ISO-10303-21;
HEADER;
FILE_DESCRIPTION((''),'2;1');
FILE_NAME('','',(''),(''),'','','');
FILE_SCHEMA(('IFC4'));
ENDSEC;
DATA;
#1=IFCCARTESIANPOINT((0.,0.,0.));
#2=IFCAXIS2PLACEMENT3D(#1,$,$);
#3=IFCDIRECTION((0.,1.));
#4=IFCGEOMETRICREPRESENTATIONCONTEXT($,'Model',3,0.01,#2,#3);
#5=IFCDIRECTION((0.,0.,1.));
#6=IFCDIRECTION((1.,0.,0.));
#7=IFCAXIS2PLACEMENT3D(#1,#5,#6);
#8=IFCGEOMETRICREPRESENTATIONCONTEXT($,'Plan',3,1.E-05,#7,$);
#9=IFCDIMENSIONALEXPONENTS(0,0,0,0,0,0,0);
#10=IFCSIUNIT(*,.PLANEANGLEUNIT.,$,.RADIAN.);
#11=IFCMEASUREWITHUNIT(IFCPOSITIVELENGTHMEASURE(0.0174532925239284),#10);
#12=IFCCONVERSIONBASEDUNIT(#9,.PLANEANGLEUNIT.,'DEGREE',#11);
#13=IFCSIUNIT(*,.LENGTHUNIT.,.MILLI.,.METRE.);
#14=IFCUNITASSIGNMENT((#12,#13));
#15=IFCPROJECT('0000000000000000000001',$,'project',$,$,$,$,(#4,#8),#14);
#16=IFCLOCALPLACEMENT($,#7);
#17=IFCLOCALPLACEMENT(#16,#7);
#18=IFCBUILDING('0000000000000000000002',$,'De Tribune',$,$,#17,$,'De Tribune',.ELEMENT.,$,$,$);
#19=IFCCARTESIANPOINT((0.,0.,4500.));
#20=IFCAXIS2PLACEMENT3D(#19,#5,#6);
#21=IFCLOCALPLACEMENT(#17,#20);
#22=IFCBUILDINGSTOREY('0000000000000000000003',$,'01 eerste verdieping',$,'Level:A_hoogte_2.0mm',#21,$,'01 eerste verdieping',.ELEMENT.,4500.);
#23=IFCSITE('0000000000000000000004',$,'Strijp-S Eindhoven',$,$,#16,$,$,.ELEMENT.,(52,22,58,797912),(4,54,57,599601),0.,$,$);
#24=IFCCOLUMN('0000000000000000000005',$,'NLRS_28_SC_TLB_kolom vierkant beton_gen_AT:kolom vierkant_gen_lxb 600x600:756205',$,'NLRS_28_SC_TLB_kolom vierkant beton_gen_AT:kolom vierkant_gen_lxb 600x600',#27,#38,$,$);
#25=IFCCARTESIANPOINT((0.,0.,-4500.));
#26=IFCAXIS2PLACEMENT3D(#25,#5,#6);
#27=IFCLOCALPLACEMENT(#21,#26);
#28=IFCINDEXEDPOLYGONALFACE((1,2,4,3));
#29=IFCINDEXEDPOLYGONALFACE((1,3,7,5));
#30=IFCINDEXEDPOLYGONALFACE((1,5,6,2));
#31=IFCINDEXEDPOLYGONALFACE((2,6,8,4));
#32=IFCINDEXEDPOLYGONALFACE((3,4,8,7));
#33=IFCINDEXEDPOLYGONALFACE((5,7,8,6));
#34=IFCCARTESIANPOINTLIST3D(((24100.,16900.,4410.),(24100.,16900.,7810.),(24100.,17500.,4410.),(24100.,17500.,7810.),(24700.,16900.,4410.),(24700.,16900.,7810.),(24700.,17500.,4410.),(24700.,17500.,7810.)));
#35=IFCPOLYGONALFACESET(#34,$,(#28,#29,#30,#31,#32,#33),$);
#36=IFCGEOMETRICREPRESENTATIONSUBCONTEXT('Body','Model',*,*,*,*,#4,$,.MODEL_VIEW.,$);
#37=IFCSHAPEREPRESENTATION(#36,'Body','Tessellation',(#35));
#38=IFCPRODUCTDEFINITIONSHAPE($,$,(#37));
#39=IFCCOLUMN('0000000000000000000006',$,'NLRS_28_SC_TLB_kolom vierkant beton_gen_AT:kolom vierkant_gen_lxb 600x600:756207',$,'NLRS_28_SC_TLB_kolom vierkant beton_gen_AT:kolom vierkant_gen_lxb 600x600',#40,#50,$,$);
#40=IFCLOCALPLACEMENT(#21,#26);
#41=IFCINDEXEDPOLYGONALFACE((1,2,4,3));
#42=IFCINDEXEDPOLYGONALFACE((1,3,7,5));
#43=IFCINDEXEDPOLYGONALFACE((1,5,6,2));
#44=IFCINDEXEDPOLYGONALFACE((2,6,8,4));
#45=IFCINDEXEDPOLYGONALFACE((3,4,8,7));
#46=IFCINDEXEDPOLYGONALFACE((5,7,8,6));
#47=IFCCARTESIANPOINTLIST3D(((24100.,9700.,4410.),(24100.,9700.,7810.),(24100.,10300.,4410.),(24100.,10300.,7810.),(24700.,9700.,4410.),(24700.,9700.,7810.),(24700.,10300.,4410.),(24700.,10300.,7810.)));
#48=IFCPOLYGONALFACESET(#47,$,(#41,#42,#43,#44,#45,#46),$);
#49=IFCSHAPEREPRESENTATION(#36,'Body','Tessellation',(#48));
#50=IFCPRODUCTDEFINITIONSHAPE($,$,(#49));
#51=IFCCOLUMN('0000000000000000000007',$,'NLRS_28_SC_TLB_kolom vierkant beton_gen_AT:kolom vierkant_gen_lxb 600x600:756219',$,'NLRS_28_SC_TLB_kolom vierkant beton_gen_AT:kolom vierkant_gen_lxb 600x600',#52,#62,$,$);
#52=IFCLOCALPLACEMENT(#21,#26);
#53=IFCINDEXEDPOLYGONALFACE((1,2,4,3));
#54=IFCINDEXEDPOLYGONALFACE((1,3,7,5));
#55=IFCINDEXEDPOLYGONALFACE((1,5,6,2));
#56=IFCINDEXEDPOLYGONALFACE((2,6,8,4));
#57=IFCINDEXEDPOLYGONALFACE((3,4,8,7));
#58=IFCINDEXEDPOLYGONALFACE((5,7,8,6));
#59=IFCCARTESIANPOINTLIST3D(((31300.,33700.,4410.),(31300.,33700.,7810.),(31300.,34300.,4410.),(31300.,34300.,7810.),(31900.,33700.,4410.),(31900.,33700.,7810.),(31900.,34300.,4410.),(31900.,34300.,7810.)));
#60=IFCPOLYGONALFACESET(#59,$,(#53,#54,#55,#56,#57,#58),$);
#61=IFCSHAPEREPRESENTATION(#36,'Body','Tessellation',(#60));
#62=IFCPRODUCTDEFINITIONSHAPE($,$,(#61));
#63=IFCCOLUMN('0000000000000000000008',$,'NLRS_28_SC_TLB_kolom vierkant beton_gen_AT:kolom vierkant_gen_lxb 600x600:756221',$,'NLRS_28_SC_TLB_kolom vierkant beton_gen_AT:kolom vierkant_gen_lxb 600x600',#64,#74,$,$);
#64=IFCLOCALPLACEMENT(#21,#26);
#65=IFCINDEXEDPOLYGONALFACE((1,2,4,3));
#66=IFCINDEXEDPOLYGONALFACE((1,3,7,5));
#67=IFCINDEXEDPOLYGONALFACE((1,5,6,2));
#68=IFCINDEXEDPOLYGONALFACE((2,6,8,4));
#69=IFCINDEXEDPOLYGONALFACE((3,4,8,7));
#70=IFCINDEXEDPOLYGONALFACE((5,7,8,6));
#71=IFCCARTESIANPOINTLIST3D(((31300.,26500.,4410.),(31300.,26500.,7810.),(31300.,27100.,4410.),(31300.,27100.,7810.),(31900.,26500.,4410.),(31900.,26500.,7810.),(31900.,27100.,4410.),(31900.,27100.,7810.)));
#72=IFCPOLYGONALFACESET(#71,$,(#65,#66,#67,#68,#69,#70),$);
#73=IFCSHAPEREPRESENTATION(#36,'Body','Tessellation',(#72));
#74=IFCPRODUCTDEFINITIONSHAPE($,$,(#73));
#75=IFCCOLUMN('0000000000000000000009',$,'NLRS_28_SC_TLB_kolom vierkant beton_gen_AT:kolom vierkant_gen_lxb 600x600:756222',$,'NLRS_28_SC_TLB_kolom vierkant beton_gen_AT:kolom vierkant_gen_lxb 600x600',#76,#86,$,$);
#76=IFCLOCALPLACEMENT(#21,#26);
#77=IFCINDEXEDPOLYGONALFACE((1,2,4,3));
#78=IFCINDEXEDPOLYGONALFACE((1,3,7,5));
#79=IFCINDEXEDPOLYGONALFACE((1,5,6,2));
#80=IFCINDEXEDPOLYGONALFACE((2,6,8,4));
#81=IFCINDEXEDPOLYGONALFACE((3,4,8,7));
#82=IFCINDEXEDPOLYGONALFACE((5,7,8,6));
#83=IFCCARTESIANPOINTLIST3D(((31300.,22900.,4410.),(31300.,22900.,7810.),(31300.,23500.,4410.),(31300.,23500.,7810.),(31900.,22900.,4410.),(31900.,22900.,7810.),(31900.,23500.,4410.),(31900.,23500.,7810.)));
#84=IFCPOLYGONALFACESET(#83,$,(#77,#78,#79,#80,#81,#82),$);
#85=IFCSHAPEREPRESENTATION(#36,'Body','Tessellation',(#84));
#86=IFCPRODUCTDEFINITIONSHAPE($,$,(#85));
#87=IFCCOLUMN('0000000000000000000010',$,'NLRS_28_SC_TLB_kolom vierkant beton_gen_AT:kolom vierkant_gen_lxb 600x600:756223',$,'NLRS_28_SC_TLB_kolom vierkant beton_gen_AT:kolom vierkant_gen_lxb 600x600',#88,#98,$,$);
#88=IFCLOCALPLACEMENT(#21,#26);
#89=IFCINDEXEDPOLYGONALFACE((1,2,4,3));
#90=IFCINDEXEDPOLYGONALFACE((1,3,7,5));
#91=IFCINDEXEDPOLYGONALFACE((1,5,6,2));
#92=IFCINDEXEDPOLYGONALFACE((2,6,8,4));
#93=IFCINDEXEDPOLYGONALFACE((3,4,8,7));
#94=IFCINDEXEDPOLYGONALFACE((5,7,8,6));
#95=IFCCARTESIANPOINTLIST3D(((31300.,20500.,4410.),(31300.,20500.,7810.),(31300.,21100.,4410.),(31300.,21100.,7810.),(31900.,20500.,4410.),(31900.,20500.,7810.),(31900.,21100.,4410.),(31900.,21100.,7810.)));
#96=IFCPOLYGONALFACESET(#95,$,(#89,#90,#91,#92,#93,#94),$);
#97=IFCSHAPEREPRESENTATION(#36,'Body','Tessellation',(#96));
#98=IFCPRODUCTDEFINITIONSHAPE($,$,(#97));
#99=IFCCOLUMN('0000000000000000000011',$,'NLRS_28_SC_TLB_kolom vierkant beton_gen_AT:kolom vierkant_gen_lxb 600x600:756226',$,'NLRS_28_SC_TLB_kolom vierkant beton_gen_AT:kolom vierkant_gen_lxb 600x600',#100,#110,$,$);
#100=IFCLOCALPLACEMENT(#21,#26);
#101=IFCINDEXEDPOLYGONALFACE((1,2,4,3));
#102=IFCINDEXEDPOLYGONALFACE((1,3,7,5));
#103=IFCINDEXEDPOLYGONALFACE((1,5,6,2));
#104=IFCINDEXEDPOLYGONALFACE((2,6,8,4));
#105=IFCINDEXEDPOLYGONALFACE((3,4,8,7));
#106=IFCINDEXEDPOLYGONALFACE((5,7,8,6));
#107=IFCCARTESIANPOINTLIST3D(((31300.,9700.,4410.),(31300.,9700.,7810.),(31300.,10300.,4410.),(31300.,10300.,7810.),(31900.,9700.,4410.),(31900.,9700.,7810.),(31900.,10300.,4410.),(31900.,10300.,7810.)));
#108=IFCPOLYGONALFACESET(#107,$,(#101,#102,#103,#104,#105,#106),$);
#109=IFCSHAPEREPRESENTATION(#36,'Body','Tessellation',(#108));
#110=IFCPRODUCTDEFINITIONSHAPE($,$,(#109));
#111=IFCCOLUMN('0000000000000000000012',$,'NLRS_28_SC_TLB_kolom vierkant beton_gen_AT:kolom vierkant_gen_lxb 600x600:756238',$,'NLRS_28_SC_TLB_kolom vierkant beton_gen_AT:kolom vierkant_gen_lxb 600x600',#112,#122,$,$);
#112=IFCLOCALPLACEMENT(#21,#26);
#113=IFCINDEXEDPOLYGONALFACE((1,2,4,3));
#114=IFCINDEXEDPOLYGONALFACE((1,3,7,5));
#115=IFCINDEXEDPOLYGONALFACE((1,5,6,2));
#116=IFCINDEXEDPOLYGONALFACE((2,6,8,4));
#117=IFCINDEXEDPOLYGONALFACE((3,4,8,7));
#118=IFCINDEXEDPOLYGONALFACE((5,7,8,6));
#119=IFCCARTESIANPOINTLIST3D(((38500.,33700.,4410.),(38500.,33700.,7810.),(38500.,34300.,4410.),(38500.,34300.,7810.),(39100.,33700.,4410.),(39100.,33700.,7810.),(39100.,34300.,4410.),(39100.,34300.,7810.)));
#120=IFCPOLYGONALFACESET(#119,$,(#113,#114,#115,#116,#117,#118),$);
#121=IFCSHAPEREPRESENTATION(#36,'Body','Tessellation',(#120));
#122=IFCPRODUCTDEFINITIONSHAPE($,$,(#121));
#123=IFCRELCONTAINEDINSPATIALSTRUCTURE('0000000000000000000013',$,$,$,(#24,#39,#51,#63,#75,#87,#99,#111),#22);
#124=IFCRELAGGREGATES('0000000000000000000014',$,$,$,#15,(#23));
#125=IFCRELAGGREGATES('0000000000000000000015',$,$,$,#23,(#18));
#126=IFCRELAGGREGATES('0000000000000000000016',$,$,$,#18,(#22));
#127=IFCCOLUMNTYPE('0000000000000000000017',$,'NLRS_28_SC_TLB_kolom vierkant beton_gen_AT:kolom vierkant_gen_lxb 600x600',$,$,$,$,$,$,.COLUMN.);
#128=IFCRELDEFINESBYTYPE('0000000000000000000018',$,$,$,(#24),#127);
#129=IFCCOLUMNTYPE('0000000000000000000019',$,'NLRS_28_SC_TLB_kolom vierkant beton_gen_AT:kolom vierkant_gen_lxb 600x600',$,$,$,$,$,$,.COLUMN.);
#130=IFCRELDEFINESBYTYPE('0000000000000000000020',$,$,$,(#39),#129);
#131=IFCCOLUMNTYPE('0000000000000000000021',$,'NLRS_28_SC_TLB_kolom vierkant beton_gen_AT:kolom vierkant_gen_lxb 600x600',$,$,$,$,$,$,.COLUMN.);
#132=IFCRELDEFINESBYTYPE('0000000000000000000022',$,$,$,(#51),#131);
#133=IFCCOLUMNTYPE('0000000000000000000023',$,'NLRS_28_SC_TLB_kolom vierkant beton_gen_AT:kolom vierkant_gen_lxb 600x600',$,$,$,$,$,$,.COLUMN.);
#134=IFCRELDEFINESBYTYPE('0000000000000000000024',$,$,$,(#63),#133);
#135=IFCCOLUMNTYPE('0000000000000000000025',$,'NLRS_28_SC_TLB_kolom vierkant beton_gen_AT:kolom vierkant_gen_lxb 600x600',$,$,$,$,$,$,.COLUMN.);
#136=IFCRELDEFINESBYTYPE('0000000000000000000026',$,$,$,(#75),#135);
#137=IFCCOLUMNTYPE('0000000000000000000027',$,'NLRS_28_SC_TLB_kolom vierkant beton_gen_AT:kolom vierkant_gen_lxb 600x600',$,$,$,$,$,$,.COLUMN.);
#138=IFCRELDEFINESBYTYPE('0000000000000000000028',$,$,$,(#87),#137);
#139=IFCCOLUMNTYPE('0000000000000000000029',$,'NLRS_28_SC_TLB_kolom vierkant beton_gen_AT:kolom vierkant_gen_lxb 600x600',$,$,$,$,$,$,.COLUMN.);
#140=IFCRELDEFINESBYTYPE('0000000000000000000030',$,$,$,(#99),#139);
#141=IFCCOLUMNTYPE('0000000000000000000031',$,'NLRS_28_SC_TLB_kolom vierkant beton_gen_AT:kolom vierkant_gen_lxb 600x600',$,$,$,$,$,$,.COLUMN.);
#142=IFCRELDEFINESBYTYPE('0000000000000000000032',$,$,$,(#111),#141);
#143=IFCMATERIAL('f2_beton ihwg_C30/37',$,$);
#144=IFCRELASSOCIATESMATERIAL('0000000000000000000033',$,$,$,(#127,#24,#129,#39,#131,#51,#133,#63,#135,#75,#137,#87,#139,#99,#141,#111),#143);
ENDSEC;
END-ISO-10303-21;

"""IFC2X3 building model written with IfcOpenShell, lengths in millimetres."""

from ifc_helpers import new_model, entity, si_unit, converted_unit, direction, frame, frame_2d, origin, origin_with_axes, place, context, subcontext, project, spatial, rectangle, extrude, source, transform, mapped, material, type_object, element, save


model = new_model("IFC2X3")

# Units and contexts
model_context = context("Model", 3, precision=0.01, world=origin(), true_north=direction((0.0, 1.0)))
plan_context = context("Plan", 3, precision=1e-05, world=origin_with_axes())
body_context = subcontext(model_context, "Body", "Model", "MODEL_VIEW")
ifc_project = project(units=[converted_unit("PLANEANGLEUNIT", "DEGREE", entity("IfcPositiveLengthMeasure", 0.0174532925239284), si_unit("PLANEANGLEUNIT", "RADIAN"), dimensions=[0, 0, 0, 0, 0, 0, 0]), si_unit("LENGTHUNIT", "METRE", prefix="MILLI")], contexts=[model_context, plan_context])

# Site, building, storey
site_placement = place(None, origin_with_axes())
site = spatial("IfcSite", under=ifc_project, at=site_placement, Name="Strijp-S Eindhoven", CompositionType="ELEMENT", RefLatitude=(52, 22, 58, 797912), RefLongitude=(4, 54, 57, 599601), RefElevation=0.0)
building_placement = place(site_placement, origin_with_axes())
building = spatial("IfcBuilding", under=site, at=building_placement, Name="De Tribune", LongName="De Tribune", CompositionType="ELEMENT")
storey_placement = place(building_placement, frame((0.0, 0.0, 4500.0), z_axis=(0.0, 0.0, 1.0), x_axis=(1.0, 0.0, 0.0)))
storey = spatial("IfcBuildingStorey", under=building, at=storey_placement, Name="01 eerste verdieping", ObjectType="Level:A_hoogte_2.0mm", LongName="01 eerste verdieping", CompositionType="ELEMENT", Elevation=4500.0)

# Columns
ifc_material = material(Name="f2_beton ihwg_C30/37")
column_type_1 = type_object("IfcColumnType", Name="NLRS_28_SC_TLB_kolom vierkant beton_gen_AT:kolom vierkant_gen_lxb 600x600", PredefinedType="COLUMN", material=ifc_material)
shared_shape_1 = source(origin(), body_context, "Body", "SweptSolid", [
    extrude(rectangle(XDim=600.0, YDim=600.0, at=frame_2d((0.0, 0.0), x_axis=(1.0, 0.0))), frame((24400.0, 17200.0, 4410.0), z_axis=(0.0, 0.0, 1.0), x_axis=(-1.0, 0.0, 0.0)), (0.0, 0.0, 1.0), 3400.0),
])
column_1_placement = place(storey_placement, frame((0.0, 0.0, -4500.0), z_axis=(0.0, 0.0, 1.0), x_axis=(1.0, 0.0, 0.0)))
element("IfcColumn", 1, at=column_1_placement, inside=storey, type_object=column_type_1, material=ifc_material, Name="NLRS_28_SC_TLB_kolom vierkant beton_gen_AT:kolom vierkant_gen_lxb 600x600:756205", ObjectType="NLRS_28_SC_TLB_kolom vierkant beton_gen_AT:kolom vierkant_gen_lxb 600x600", context=body_context, shape_type="MappedRepresentation", body=[
    mapped(shared_shape_1, transform((0.0, 0.0, 0.0), scale=1.0)),
])
column_type_2 = type_object("IfcColumnType", Name="NLRS_28_SC_TLB_kolom vierkant beton_gen_AT:kolom vierkant_gen_lxb 600x600", PredefinedType="COLUMN", material=ifc_material)
shared_shape_2 = source(origin(), body_context, "Body", "SweptSolid", [
    extrude(rectangle(XDim=600.0, YDim=600.0, at=frame_2d((0.0, 0.0), x_axis=(1.0, 0.0))), frame((24400.0, 10000.0, 4410.0), z_axis=(0.0, 0.0, 1.0), x_axis=(0.0, -1.0, 0.0)), (0.0, 0.0, 1.0), 3400.0),
])
column_2_placement = place(storey_placement, frame((0.0, 0.0, -4500.0), z_axis=(0.0, 0.0, 1.0), x_axis=(1.0, 0.0, 0.0)))
element("IfcColumn", 2, at=column_2_placement, inside=storey, type_object=column_type_2, material=ifc_material, Name="NLRS_28_SC_TLB_kolom vierkant beton_gen_AT:kolom vierkant_gen_lxb 600x600:756207", ObjectType="NLRS_28_SC_TLB_kolom vierkant beton_gen_AT:kolom vierkant_gen_lxb 600x600", context=body_context, shape_type="MappedRepresentation", body=[
    mapped(shared_shape_2, transform((0.0, 0.0, 0.0), scale=1.0)),
])
column_type_3 = type_object("IfcColumnType", Name="NLRS_28_SC_TLB_kolom vierkant beton_gen_AT:kolom vierkant_gen_lxb 600x600", PredefinedType="COLUMN", material=ifc_material)
shared_shape_3 = source(origin(), body_context, "Body", "SweptSolid", [
    extrude(rectangle(XDim=600.0, YDim=600.0, at=frame_2d((0.0, 0.0), x_axis=(1.0, 0.0))), frame((31600.0, 34000.0, 4410.0), z_axis=(0.0, 0.0, 1.0), x_axis=(0.0, -1.0, 0.0)), (0.0, 0.0, 1.0), 3400.0),
])
column_3_placement = place(storey_placement, frame((0.0, 0.0, -4500.0), z_axis=(0.0, 0.0, 1.0), x_axis=(1.0, 0.0, 0.0)))
element("IfcColumn", 3, at=column_3_placement, inside=storey, type_object=column_type_3, material=ifc_material, Name="NLRS_28_SC_TLB_kolom vierkant beton_gen_AT:kolom vierkant_gen_lxb 600x600:756219", ObjectType="NLRS_28_SC_TLB_kolom vierkant beton_gen_AT:kolom vierkant_gen_lxb 600x600", context=body_context, shape_type="MappedRepresentation", body=[
    mapped(shared_shape_3, transform((0.0, 0.0, 0.0), scale=1.0)),
])
column_type_4 = type_object("IfcColumnType", Name="NLRS_28_SC_TLB_kolom vierkant beton_gen_AT:kolom vierkant_gen_lxb 600x600", PredefinedType="COLUMN", material=ifc_material)
shared_shape_4 = source(origin(), body_context, "Body", "SweptSolid", [
    extrude(rectangle(XDim=600.0, YDim=600.0, at=frame_2d((0.0, 0.0), x_axis=(1.0, 0.0))), frame((31600.0, 26800.0, 4410.0), z_axis=(0.0, 0.0, 1.0), x_axis=(-1.0, 0.0, 0.0)), (0.0, 0.0, 1.0), 3400.0),
])
column_4_placement = place(storey_placement, frame((0.0, 0.0, -4500.0), z_axis=(0.0, 0.0, 1.0), x_axis=(1.0, 0.0, 0.0)))
element("IfcColumn", 4, at=column_4_placement, inside=storey, type_object=column_type_4, material=ifc_material, Name="NLRS_28_SC_TLB_kolom vierkant beton_gen_AT:kolom vierkant_gen_lxb 600x600:756221", ObjectType="NLRS_28_SC_TLB_kolom vierkant beton_gen_AT:kolom vierkant_gen_lxb 600x600", context=body_context, shape_type="MappedRepresentation", body=[
    mapped(shared_shape_4, transform((0.0, 0.0, 0.0), scale=1.0)),
])
column_type_5 = type_object("IfcColumnType", Name="NLRS_28_SC_TLB_kolom vierkant beton_gen_AT:kolom vierkant_gen_lxb 600x600", PredefinedType="COLUMN", material=ifc_material)
shared_shape_5 = source(origin(), body_context, "Body", "SweptSolid", [
    extrude(rectangle(XDim=600.0, YDim=600.0, at=frame_2d((0.0, 0.0), x_axis=(1.0, 0.0))), frame((31600.0, 23200.0, 4410.0), z_axis=(0.0, 0.0, 1.0), x_axis=(-1.0, 0.0, 0.0)), (0.0, 0.0, 1.0), 3400.0),
])
column_5_placement = place(storey_placement, frame((0.0, 0.0, -4500.0), z_axis=(0.0, 0.0, 1.0), x_axis=(1.0, 0.0, 0.0)))
element("IfcColumn", 5, at=column_5_placement, inside=storey, type_object=column_type_5, material=ifc_material, Name="NLRS_28_SC_TLB_kolom vierkant beton_gen_AT:kolom vierkant_gen_lxb 600x600:756222", ObjectType="NLRS_28_SC_TLB_kolom vierkant beton_gen_AT:kolom vierkant_gen_lxb 600x600", context=body_context, shape_type="MappedRepresentation", body=[
    mapped(shared_shape_5, transform((0.0, 0.0, 0.0), scale=1.0)),
])
column_type_6 = type_object("IfcColumnType", Name="NLRS_28_SC_TLB_kolom vierkant beton_gen_AT:kolom vierkant_gen_lxb 600x600", PredefinedType="COLUMN", material=ifc_material)
shared_shape_6 = source(origin(), body_context, "Body", "SweptSolid", [
    extrude(rectangle(XDim=600.0, YDim=600.0, at=frame_2d((0.0, 0.0), x_axis=(1.0, 0.0))), frame((31600.0, 20800.0, 4410.0), z_axis=(0.0, 0.0, 1.0), x_axis=(-1.0, 0.0, 0.0)), (0.0, 0.0, 1.0), 3400.0),
])
column_6_placement = place(storey_placement, frame((0.0, 0.0, -4500.0), z_axis=(0.0, 0.0, 1.0), x_axis=(1.0, 0.0, 0.0)))
element("IfcColumn", 6, at=column_6_placement, inside=storey, type_object=column_type_6, material=ifc_material, Name="NLRS_28_SC_TLB_kolom vierkant beton_gen_AT:kolom vierkant_gen_lxb 600x600:756223", ObjectType="NLRS_28_SC_TLB_kolom vierkant beton_gen_AT:kolom vierkant_gen_lxb 600x600", context=body_context, shape_type="MappedRepresentation", body=[
    mapped(shared_shape_6, transform((0.0, 0.0, 0.0), scale=1.0)),
])
column_type_7 = type_object("IfcColumnType", Name="NLRS_28_SC_TLB_kolom vierkant beton_gen_AT:kolom vierkant_gen_lxb 600x600", PredefinedType="COLUMN", material=ifc_material)
shared_shape_7 = source(origin(), body_context, "Body", "SweptSolid", [
    extrude(rectangle(XDim=600.0, YDim=600.0, at=frame_2d((0.0, 0.0), x_axis=(1.0, 0.0))), frame((31600.0, 10000.0, 4410.0), z_axis=(0.0, 0.0, 1.0), x_axis=(0.0, -1.0, 0.0)), (0.0, 0.0, 1.0), 3400.0),
])
column_7_placement = place(storey_placement, frame((0.0, 0.0, -4500.0), z_axis=(0.0, 0.0, 1.0), x_axis=(1.0, 0.0, 0.0)))
element("IfcColumn", 7, at=column_7_placement, inside=storey, type_object=column_type_7, material=ifc_material, Name="NLRS_28_SC_TLB_kolom vierkant beton_gen_AT:kolom vierkant_gen_lxb 600x600:756226", ObjectType="NLRS_28_SC_TLB_kolom vierkant beton_gen_AT:kolom vierkant_gen_lxb 600x600", context=body_context, shape_type="MappedRepresentation", body=[
    mapped(shared_shape_7, transform((0.0, 0.0, 0.0), scale=1.0)),
])
column_type_8 = type_object("IfcColumnType", Name="NLRS_28_SC_TLB_kolom vierkant beton_gen_AT:kolom vierkant_gen_lxb 600x600", PredefinedType="COLUMN", material=ifc_material)
shared_shape_8 = source(origin(), body_context, "Body", "SweptSolid", [
    extrude(rectangle(XDim=600.0, YDim=600.0, at=frame_2d((0.0, 0.0), x_axis=(1.0, 0.0))), frame((38800.0, 34000.0, 4410.0), z_axis=(0.0, 0.0, 1.0), x_axis=(0.0, -1.0, 0.0)), (0.0, 0.0, 1.0), 3400.0),
])
column_8_placement = place(storey_placement, frame((0.0, 0.0, -4500.0), z_axis=(0.0, 0.0, 1.0), x_axis=(1.0, 0.0, 0.0)))
element("IfcColumn", 8, at=column_8_placement, inside=storey, type_object=column_type_8, material=ifc_material, Name="NLRS_28_SC_TLB_kolom vierkant beton_gen_AT:kolom vierkant_gen_lxb 600x600:756238", ObjectType="NLRS_28_SC_TLB_kolom vierkant beton_gen_AT:kolom vierkant_gen_lxb 600x600", context=body_context, shape_type="MappedRepresentation", body=[
    mapped(shared_shape_8, transform((0.0, 0.0, 0.0), scale=1.0)),
])

save(model, "model.ifc")
